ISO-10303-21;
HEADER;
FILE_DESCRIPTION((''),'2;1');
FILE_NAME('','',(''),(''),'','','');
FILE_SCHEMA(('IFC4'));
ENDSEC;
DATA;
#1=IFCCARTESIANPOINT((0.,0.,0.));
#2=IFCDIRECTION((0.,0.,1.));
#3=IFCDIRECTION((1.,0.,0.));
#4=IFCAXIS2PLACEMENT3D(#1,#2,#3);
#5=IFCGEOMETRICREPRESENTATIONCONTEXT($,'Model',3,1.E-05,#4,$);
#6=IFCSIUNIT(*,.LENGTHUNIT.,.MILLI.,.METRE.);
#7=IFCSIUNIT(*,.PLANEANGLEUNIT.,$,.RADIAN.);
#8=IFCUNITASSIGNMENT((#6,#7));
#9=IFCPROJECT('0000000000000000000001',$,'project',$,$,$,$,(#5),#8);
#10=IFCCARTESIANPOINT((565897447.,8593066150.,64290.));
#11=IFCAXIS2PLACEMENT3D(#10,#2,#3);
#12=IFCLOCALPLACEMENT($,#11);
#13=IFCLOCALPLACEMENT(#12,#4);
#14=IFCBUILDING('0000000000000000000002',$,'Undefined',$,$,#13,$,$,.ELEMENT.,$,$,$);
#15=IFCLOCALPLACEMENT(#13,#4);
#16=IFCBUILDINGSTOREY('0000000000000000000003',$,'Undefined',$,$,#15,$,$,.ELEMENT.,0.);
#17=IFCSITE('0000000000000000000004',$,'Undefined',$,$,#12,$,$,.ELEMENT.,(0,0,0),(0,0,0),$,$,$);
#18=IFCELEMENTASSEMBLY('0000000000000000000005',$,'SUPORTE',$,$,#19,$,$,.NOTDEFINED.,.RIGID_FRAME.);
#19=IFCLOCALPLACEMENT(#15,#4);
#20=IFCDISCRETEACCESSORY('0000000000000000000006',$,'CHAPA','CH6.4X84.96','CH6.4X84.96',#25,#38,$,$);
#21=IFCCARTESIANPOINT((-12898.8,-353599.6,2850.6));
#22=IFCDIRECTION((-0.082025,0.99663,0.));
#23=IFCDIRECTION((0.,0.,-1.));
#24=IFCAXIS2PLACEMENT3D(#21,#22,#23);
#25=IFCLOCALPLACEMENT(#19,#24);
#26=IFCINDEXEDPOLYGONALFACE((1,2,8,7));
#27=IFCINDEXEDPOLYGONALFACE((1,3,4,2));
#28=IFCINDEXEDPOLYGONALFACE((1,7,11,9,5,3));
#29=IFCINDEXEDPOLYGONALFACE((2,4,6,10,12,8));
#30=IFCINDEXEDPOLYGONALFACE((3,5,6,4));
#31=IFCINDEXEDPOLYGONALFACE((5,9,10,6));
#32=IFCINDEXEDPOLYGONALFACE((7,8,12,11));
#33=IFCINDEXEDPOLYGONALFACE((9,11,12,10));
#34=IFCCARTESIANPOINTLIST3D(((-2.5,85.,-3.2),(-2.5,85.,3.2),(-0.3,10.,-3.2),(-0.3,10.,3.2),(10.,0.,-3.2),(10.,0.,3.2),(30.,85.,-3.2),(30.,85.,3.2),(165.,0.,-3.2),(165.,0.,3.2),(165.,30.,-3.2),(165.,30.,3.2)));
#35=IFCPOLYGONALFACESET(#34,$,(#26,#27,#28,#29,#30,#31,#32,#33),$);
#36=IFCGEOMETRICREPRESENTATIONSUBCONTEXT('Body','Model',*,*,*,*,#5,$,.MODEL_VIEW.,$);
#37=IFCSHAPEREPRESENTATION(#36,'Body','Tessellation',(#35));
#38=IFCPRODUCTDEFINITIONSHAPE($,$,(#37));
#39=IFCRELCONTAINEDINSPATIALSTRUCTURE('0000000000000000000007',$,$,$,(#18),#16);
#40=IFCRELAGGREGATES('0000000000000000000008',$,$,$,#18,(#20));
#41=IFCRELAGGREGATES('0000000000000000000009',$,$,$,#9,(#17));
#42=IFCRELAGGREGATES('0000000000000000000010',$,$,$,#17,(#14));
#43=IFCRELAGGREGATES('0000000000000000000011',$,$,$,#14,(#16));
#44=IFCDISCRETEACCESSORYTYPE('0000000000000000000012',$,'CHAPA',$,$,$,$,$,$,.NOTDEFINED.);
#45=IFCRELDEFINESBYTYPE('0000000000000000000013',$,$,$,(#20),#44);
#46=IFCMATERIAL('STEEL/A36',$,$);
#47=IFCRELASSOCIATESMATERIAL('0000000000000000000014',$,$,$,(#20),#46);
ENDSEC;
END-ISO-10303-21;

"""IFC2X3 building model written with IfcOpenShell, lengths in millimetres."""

from ifc_helpers import new_model, si_unit, frame, origin_with_axes, place, context, subcontext, project, spatial, polyline, outline, extrude, material, type_object, element, aggregate, save


model = new_model("IFC2X3")

# Units and contexts
model_context = context("Model", 3, precision=1e-05, world=origin_with_axes())
body_context = subcontext(model_context, "Body", "Model", "MODEL_VIEW")
ifc_project = project(units=[si_unit("LENGTHUNIT", "METRE", prefix="MILLI"), si_unit("PLANEANGLEUNIT", "RADIAN")], contexts=[model_context])

# Site, building, storey
site_placement = place(None, frame((565897447.0, 8593066150.0, 64290.0), z_axis=(0.0, 0.0, 1.0), x_axis=(1.0, 0.0, 0.0)))
site = spatial("IfcSite", under=ifc_project, at=site_placement, Name="Undefined", CompositionType="ELEMENT", RefLatitude=(0, 0, 0), RefLongitude=(0, 0, 0))
building_placement = place(site_placement, origin_with_axes())
building = spatial("IfcBuilding", under=site, at=building_placement, Name="Undefined", CompositionType="ELEMENT")
storey_placement = place(building_placement, origin_with_axes())
storey = spatial("IfcBuildingStorey", under=building, at=storey_placement, Name="Undefined", CompositionType="ELEMENT", Elevation=0.0)

# Shared definitions
ifc_material_1 = material(Name="STEEL/A36")

# Shared definitions
discrete_accessory_type_1 = type_object("IfcDiscreteAccessoryType", Name="CHAPA")

# Element assembly, discrete accessory
assembly_1_placement = place(storey_placement, origin_with_axes())
assembly_1 = element("IfcElementAssembly", 1, at=assembly_1_placement, inside=storey, Name="SUPORTE", AssemblyPlace="NOTDEFINED", PredefinedType="RIGID_FRAME")
discrete_accessory_1_placement = place(assembly_1_placement, frame((-12898.8, -353599.6, 2850.6), z_axis=(-0.082025, 0.99663, 0.0), x_axis=(0.0, 0.0, -1.0)))
discrete_accessory_1 = element("IfcDiscreteAccessory", 2, at=discrete_accessory_1_placement, type_object=discrete_accessory_type_1, material=ifc_material_1, Name="CHAPA", Description="CH6.4X84.96", ObjectType="CH6.4X84.96", context=body_context, shape_type="SweptSolid", body=[
    extrude(outline(polyline([(-0.3, 10.0), (10.0, 0.0), (165.0, 0.0), (165.0, 30.0), (30.0, 85.0), (-2.5, 85.0), (-0.3, 10.0)])), frame((0.0, 0.0, -3.2), z_axis=(0.0, 0.0, 1.0), x_axis=(1.0, 0.0, 0.0)), (0.0, 0.0, 1.0), 6.4),
])
aggregate(assembly_1, [discrete_accessory_1])

save(model, "model.ifc")
